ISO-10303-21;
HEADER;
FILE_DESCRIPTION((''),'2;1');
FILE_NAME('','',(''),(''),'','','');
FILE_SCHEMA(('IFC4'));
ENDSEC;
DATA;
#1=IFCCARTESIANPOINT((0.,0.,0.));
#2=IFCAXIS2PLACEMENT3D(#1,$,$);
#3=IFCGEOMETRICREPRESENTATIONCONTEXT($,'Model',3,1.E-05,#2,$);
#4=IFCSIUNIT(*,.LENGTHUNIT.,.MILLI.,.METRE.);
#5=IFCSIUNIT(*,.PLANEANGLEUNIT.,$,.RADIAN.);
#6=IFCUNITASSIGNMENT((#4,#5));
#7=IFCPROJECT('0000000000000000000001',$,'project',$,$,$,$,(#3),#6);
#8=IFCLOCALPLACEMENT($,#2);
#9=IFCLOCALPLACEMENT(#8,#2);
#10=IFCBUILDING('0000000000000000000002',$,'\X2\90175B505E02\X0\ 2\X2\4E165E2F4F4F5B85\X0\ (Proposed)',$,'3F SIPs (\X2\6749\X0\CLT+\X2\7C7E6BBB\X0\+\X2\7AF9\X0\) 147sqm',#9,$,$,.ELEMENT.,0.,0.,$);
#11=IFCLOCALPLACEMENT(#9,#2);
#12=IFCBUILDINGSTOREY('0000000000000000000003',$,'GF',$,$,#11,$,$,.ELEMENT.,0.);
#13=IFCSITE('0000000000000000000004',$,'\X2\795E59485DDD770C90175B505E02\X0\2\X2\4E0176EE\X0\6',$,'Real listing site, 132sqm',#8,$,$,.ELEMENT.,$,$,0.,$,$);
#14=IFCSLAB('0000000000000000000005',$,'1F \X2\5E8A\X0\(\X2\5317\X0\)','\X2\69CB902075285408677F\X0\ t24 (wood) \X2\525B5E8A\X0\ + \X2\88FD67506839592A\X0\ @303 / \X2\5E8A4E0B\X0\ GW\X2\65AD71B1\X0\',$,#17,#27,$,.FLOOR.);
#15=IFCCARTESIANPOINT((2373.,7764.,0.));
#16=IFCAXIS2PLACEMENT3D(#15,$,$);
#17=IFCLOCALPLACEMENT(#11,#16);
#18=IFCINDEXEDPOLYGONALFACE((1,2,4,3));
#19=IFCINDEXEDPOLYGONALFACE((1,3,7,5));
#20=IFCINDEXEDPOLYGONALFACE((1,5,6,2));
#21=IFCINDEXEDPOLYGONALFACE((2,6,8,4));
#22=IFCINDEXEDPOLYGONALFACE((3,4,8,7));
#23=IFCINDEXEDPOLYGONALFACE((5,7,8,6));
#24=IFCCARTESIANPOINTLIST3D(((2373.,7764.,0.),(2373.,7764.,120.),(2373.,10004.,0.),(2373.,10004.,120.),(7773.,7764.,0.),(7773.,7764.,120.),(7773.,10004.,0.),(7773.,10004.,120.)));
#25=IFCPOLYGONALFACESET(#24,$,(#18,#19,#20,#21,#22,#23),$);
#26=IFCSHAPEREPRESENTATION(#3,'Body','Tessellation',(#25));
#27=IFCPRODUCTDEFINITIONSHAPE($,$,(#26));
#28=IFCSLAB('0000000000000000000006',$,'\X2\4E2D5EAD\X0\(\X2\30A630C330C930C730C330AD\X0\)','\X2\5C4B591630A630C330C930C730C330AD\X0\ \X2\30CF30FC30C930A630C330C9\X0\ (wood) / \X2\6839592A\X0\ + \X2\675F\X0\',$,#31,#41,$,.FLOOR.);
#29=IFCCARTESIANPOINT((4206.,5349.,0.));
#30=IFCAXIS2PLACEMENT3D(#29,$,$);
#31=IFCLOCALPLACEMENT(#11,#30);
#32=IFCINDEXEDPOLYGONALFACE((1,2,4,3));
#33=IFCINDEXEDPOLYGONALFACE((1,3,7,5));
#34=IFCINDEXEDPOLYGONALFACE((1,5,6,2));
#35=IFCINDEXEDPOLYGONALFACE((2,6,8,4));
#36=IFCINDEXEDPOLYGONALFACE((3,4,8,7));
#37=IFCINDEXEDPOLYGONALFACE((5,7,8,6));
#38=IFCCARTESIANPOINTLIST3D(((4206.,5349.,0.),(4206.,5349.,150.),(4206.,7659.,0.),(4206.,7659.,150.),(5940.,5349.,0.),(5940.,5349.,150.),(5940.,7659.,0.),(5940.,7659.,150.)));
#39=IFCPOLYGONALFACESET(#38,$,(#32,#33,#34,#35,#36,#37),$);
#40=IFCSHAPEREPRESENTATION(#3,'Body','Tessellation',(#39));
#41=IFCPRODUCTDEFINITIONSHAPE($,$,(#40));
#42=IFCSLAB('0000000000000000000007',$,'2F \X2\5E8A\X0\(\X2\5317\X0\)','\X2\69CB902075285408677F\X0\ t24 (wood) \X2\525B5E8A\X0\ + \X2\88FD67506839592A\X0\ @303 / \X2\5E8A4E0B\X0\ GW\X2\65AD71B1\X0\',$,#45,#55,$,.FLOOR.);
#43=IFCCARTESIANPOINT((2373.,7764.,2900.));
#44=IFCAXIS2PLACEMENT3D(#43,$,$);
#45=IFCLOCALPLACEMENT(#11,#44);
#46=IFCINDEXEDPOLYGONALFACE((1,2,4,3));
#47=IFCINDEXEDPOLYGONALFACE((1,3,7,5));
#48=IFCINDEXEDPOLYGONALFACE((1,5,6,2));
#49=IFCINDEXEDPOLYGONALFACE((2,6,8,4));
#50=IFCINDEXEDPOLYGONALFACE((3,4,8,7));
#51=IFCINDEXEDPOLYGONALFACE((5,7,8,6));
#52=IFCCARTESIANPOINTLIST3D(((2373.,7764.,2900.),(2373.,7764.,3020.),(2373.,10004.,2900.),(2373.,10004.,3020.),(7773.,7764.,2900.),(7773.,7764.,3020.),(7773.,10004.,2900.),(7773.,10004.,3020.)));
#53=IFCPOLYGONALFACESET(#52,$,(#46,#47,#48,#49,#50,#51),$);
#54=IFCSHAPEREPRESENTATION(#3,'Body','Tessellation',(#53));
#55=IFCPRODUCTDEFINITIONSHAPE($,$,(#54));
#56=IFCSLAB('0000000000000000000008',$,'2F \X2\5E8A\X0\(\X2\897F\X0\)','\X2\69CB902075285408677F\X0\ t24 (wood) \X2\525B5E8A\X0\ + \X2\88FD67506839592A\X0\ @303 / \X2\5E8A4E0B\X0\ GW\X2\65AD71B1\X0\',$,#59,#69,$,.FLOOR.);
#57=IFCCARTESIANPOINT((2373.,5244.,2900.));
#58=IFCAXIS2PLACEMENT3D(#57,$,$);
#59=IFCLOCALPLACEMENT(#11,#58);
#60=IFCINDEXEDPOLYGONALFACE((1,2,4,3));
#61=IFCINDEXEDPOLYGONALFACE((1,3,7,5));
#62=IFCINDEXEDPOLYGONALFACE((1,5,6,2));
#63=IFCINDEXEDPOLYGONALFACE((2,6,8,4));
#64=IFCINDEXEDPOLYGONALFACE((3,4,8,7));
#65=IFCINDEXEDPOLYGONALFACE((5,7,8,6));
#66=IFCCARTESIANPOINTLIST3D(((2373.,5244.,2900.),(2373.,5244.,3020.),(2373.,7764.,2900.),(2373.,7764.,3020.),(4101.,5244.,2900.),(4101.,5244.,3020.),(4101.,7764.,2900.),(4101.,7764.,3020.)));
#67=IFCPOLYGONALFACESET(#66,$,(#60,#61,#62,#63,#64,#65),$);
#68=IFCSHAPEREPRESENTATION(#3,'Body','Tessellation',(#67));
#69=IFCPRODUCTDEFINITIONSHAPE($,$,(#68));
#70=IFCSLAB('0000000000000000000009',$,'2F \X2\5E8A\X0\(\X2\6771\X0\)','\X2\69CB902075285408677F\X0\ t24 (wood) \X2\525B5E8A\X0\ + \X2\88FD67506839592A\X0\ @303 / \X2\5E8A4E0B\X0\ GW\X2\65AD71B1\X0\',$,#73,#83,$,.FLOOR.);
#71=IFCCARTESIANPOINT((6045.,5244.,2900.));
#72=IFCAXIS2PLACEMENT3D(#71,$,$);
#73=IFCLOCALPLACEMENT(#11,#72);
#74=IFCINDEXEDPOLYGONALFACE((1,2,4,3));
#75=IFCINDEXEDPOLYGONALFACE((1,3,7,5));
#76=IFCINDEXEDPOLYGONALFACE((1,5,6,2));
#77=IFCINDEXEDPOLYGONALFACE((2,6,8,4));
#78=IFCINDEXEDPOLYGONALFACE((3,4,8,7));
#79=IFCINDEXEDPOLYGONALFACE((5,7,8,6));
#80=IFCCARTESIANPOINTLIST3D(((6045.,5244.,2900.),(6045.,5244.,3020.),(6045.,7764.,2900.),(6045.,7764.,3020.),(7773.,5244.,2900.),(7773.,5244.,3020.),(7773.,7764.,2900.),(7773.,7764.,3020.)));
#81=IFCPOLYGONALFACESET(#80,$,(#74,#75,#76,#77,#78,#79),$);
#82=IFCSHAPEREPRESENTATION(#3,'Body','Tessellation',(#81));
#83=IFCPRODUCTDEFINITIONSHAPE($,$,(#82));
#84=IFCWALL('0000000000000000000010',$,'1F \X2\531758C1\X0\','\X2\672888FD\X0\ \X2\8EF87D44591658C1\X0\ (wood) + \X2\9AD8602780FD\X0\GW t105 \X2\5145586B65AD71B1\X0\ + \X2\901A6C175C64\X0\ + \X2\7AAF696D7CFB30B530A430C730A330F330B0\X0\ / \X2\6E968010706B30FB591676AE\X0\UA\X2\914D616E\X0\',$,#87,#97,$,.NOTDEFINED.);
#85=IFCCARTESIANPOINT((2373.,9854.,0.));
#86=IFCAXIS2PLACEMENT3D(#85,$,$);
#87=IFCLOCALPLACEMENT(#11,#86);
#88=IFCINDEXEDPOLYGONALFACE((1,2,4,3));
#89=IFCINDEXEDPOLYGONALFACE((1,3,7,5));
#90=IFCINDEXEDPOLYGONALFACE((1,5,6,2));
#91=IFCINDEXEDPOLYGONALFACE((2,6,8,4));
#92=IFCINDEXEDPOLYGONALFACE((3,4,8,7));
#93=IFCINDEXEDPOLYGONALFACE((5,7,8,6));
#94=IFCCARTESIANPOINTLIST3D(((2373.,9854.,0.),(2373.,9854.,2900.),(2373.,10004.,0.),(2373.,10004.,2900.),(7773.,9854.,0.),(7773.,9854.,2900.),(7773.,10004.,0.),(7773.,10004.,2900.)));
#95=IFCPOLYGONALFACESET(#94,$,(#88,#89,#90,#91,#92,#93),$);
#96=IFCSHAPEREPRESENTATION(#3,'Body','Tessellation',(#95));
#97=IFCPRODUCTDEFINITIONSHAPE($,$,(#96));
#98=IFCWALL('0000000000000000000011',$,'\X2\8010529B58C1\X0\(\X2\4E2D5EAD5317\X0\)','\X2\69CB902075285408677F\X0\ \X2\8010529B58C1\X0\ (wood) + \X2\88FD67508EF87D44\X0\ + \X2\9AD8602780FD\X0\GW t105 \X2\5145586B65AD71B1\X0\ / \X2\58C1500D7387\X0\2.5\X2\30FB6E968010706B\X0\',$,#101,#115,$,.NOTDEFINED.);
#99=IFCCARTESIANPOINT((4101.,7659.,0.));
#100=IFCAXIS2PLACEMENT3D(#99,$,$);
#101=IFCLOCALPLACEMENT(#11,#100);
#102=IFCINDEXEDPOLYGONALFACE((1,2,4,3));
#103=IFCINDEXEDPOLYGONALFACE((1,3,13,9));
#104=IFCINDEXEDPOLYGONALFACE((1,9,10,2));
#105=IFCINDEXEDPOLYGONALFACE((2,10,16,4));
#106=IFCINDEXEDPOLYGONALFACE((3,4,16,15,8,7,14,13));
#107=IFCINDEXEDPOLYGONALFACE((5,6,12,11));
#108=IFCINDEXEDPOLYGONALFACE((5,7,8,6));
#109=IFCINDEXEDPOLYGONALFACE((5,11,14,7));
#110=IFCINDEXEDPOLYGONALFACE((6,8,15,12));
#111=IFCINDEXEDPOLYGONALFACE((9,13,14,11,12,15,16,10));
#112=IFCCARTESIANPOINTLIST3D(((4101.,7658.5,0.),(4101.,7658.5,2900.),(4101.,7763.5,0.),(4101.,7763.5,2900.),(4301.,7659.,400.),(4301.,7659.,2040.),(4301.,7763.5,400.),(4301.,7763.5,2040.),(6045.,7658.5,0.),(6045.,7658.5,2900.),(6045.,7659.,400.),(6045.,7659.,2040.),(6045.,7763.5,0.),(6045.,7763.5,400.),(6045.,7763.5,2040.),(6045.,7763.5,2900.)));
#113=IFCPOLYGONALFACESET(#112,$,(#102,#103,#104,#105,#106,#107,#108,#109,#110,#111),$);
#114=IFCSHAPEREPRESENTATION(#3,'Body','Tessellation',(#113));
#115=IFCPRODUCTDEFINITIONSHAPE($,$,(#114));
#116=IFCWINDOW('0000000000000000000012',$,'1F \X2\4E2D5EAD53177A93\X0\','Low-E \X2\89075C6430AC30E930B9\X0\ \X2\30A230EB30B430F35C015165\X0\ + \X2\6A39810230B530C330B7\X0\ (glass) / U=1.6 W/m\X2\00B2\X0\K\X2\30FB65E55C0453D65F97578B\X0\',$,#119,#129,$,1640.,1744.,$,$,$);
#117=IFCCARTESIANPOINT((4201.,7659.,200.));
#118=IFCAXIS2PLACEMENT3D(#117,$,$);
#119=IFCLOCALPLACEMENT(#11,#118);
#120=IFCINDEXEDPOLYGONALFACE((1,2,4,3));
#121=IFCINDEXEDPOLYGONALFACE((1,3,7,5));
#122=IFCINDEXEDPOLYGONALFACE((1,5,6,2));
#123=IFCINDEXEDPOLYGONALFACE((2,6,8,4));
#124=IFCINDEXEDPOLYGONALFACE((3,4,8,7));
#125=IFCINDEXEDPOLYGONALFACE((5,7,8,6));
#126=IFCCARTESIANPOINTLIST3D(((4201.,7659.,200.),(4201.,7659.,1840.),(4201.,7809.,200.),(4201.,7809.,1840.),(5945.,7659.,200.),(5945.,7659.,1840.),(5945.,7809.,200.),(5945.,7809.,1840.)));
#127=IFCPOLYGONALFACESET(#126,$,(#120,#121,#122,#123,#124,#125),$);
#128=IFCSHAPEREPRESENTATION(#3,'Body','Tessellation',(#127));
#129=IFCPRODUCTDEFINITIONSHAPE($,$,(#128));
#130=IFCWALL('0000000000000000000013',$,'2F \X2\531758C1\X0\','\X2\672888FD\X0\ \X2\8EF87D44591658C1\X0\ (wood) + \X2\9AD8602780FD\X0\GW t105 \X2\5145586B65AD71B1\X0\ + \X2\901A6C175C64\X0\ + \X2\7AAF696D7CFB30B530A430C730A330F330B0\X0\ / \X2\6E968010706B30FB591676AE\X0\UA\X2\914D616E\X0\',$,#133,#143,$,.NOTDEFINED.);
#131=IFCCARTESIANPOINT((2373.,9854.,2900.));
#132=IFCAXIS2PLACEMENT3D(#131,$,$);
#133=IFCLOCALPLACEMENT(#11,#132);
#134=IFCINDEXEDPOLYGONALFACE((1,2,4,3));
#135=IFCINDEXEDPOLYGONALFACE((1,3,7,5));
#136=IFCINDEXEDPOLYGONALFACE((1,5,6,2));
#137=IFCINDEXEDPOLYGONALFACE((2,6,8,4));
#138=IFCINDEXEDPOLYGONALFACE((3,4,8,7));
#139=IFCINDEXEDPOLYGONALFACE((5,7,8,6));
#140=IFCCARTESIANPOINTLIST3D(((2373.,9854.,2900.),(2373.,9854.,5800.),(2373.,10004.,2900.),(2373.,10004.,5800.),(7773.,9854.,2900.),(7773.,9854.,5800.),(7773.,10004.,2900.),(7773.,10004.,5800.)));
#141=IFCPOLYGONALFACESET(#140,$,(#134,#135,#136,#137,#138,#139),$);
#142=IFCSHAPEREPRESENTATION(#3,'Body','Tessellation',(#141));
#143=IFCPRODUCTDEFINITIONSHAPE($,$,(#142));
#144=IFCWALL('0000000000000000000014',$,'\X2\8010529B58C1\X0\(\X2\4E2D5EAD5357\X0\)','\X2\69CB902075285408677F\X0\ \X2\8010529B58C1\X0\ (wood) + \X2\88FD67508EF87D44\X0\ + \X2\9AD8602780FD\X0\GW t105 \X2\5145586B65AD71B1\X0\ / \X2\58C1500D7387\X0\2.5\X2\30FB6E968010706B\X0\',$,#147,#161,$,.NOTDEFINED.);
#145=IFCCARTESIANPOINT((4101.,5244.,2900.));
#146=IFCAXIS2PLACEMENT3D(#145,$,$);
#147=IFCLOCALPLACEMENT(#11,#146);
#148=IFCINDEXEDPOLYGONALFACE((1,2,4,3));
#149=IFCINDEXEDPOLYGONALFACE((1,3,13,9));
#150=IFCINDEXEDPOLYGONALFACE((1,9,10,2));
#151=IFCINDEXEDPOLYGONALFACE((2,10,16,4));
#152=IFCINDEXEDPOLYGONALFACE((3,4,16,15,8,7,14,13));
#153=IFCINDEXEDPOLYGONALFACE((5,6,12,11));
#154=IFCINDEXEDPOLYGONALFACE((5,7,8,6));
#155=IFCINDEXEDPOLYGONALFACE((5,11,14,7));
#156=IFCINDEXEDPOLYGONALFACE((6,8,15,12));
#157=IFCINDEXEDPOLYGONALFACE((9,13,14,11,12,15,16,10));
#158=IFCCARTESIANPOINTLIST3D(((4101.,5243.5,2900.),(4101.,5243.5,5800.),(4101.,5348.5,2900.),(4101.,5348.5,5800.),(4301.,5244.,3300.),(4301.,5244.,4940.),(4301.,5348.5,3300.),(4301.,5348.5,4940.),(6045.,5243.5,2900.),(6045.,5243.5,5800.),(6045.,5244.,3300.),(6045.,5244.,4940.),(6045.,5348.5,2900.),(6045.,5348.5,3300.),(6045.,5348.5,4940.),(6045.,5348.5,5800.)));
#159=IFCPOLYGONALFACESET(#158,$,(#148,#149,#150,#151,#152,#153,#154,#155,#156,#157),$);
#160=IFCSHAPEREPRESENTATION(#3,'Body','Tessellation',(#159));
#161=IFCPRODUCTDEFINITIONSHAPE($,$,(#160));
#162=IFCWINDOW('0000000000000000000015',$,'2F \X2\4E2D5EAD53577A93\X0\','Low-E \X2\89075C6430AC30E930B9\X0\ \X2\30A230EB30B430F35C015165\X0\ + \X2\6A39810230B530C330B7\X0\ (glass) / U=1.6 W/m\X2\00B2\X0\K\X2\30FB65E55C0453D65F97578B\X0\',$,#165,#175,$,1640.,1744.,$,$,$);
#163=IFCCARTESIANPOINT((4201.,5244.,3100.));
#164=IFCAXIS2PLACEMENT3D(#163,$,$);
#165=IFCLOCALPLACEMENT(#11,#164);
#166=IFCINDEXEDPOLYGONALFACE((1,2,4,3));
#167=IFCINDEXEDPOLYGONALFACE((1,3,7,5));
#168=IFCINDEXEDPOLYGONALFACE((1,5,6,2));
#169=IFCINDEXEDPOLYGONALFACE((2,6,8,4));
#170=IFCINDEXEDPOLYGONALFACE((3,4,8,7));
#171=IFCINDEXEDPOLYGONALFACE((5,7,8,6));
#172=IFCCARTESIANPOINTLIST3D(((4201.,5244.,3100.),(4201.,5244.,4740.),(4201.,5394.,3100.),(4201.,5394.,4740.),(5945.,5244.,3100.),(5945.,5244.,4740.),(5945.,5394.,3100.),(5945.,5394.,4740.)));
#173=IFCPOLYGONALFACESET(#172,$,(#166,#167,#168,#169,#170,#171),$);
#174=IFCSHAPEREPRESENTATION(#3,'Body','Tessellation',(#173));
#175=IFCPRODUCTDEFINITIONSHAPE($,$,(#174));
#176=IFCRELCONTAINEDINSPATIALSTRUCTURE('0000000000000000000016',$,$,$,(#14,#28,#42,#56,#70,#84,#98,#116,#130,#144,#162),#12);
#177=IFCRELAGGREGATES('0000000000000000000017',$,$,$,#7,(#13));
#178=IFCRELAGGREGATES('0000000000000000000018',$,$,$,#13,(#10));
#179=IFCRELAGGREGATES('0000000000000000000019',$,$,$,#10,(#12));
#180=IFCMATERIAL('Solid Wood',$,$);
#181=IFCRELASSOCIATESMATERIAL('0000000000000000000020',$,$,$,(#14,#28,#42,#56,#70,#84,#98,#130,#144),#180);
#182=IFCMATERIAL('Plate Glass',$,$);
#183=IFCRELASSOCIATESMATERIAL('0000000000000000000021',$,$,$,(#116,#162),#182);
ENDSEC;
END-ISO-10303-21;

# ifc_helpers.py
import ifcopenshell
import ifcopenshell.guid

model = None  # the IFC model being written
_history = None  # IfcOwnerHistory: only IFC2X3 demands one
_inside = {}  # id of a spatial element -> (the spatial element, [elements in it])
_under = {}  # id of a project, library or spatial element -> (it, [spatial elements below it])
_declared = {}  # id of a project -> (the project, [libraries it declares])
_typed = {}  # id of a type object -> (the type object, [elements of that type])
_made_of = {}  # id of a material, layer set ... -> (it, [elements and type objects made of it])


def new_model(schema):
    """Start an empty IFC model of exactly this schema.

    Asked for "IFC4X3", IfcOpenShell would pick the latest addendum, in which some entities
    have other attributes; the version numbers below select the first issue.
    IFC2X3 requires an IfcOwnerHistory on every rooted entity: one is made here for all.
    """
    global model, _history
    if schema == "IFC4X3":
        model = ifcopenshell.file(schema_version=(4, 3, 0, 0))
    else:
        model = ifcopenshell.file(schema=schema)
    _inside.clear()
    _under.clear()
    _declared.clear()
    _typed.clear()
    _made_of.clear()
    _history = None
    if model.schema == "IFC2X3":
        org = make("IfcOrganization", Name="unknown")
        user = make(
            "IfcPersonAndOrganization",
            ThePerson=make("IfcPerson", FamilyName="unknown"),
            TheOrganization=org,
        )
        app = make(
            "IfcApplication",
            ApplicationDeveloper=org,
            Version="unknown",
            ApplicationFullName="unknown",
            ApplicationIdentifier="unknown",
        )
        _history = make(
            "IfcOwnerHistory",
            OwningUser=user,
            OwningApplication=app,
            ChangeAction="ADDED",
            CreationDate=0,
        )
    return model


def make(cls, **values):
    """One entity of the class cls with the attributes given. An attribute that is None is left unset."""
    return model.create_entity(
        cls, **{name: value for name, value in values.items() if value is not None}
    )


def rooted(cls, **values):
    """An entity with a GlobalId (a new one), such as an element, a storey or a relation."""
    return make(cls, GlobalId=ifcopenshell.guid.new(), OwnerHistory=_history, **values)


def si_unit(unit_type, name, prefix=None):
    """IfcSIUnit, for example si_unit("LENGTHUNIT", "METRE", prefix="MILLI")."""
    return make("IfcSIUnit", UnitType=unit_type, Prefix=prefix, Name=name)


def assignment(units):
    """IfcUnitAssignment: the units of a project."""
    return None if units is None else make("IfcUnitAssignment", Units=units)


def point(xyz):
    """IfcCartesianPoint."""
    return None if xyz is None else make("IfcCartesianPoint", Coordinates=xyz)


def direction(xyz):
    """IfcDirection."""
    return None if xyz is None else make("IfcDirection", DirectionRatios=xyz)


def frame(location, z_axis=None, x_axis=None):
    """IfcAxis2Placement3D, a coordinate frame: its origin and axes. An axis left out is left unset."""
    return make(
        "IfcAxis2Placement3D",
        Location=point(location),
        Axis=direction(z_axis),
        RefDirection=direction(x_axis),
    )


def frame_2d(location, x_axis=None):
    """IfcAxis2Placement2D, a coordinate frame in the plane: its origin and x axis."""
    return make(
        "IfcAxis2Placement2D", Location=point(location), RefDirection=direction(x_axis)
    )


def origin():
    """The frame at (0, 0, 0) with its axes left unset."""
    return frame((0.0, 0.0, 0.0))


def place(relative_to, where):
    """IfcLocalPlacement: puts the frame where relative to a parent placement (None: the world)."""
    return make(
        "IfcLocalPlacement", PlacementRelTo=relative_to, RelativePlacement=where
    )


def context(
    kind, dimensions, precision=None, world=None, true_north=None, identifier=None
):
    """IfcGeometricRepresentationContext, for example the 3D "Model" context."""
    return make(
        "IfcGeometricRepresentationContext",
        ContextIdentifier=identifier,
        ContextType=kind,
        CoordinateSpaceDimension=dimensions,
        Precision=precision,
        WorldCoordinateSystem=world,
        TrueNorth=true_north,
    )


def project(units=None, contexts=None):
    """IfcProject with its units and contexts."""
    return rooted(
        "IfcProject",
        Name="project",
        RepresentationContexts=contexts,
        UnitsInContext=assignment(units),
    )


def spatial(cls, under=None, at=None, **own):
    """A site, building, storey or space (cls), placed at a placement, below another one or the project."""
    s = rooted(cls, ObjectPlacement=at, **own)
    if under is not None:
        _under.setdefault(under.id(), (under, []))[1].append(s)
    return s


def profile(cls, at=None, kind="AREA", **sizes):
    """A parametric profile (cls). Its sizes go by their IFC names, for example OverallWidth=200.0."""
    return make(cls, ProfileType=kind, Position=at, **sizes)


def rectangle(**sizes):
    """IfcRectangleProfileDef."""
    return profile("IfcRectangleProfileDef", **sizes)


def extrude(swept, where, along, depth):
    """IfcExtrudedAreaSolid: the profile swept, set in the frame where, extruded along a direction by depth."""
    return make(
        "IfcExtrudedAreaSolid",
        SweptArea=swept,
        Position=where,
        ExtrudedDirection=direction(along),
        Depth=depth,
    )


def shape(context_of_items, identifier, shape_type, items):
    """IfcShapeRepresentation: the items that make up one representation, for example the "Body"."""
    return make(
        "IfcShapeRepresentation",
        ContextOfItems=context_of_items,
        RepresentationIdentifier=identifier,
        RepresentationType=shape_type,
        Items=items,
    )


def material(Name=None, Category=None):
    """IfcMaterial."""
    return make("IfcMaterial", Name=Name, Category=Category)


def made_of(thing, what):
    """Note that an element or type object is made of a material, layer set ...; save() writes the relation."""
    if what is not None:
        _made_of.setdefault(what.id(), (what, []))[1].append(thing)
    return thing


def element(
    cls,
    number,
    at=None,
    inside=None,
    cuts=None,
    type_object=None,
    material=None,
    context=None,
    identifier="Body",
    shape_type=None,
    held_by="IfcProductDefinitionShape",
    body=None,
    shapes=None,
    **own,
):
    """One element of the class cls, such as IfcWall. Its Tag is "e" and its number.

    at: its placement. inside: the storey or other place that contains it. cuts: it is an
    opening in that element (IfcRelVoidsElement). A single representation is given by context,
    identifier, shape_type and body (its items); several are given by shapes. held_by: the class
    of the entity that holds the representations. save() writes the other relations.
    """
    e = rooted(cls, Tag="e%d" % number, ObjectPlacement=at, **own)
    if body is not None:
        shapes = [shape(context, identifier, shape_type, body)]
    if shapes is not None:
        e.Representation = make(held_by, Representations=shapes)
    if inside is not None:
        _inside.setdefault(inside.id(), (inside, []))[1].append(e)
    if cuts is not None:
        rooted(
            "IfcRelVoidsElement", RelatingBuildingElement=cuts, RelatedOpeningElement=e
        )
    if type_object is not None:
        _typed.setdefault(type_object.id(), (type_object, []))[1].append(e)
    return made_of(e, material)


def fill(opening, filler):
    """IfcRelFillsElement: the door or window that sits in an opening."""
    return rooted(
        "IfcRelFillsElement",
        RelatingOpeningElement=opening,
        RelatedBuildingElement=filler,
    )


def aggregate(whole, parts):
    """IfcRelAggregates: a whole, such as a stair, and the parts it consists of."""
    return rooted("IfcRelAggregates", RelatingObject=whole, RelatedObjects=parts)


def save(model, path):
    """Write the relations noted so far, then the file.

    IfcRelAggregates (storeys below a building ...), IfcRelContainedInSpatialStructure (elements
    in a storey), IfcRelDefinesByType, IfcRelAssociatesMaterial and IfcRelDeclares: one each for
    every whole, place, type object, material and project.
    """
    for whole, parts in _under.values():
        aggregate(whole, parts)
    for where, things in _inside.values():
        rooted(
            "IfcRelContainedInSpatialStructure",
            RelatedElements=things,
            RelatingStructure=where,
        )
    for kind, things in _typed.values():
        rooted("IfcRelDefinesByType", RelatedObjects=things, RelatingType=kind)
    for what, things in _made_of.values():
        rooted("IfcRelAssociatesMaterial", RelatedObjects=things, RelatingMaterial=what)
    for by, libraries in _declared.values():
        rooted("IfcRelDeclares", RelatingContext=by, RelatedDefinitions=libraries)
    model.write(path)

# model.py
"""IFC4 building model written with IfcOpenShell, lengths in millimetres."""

from ifc_helpers import new_model, si_unit, frame, frame_2d, origin, place, context, project, spatial, rectangle, extrude, material, element, fill, save


model = new_model("IFC4")

# Units and contexts
model_context = context("Model", 3, precision=1e-05, world=origin())
ifc_project = project(units=[si_unit("LENGTHUNIT", "METRE", prefix="MILLI"), si_unit("PLANEANGLEUNIT", "RADIAN")], contexts=[model_context])

# Site, building, storey
site_placement = place(None, origin())
site = spatial("IfcSite", under=ifc_project, at=site_placement, Name="神奈川県逗子市2丁目6", ObjectType="Real listing site, 132sqm", CompositionType="ELEMENT", RefElevation=0.0)
building_placement = place(site_placement, origin())
building = spatial("IfcBuilding", under=site, at=building_placement, Name="逗子市 2世帯住宅 (Proposed)", ObjectType="3F SIPs (杉CLT+籾殻+竹) 147sqm", CompositionType="ELEMENT", ElevationOfRefHeight=0.0, ElevationOfTerrain=0.0)
storey_placement = place(building_placement, origin())
storey = spatial("IfcBuildingStorey", under=building, at=storey_placement, Name="GF", CompositionType="ELEMENT", Elevation=0.0)

# Slabs
ifc_material_1 = material(Name="Solid Wood")
slab_1_placement = place(storey_placement, frame((2373.0, 7764.0, 0.0)))
element("IfcSlab", 1, at=slab_1_placement, inside=storey, material=ifc_material_1, Name="1F 床(北)", Description="構造用合板 t24 (wood) 剛床 + 製材根太 @303 / 床下 GW断熱", PredefinedType="FLOOR", context=model_context, shape_type="SweptSolid", body=[
    extrude(rectangle(XDim=5400.0, YDim=2240.0, at=frame_2d((2700.0, 1120.0))), frame((2373.0, 7764.0, 0.0)), (0.0, 0.0, 1.0), 120.0),
])
slab_2_placement = place(storey_placement, frame((4206.0, 5349.0, 0.0)))
element("IfcSlab", 2, at=slab_2_placement, inside=storey, material=ifc_material_1, Name="中庭(ウッドデッキ)", Description="屋外ウッドデッキ ハードウッド (wood) / 根太 + 束", PredefinedType="FLOOR", context=model_context, shape_type="SweptSolid", body=[
    extrude(rectangle(XDim=1734.0, YDim=2310.0, at=frame_2d((867.0, 1155.0))), frame((4206.0, 5349.0, 0.0)), (0.0, 0.0, 1.0), 150.0),
])
slab_3_placement = place(storey_placement, frame((2373.0, 7764.0, 2900.0)))
element("IfcSlab", 3, at=slab_3_placement, inside=storey, material=ifc_material_1, Name="2F 床(北)", Description="構造用合板 t24 (wood) 剛床 + 製材根太 @303 / 床下 GW断熱", PredefinedType="FLOOR", context=model_context, shape_type="SweptSolid", body=[
    extrude(rectangle(XDim=5400.0, YDim=2240.0, at=frame_2d((2700.0, 1120.0))), frame((2373.0, 7764.0, 2900.0)), (0.0, 0.0, 1.0), 120.0),
])
slab_4_placement = place(storey_placement, frame((2373.0, 5244.0, 2900.0)))
element("IfcSlab", 4, at=slab_4_placement, inside=storey, material=ifc_material_1, Name="2F 床(西)", Description="構造用合板 t24 (wood) 剛床 + 製材根太 @303 / 床下 GW断熱", PredefinedType="FLOOR", context=model_context, shape_type="SweptSolid", body=[
    extrude(rectangle(XDim=1728.0, YDim=2520.0, at=frame_2d((864.0, 1260.0))), frame((2373.0, 5244.0, 2900.0)), (0.0, 0.0, 1.0), 120.0),
])
slab_5_placement = place(storey_placement, frame((6045.0, 5244.0, 2900.0)))
element("IfcSlab", 5, at=slab_5_placement, inside=storey, material=ifc_material_1, Name="2F 床(東)", Description="構造用合板 t24 (wood) 剛床 + 製材根太 @303 / 床下 GW断熱", PredefinedType="FLOOR", context=model_context, shape_type="SweptSolid", body=[
    extrude(rectangle(XDim=1728.0, YDim=2520.0, at=frame_2d((864.0, 1260.0))), frame((6045.0, 5244.0, 2900.0)), (0.0, 0.0, 1.0), 120.0),
])

# Wall
wall_1_placement = place(storey_placement, frame((2373.0, 9854.0, 0.0)))
element("IfcWall", 6, at=wall_1_placement, inside=storey, material=ifc_material_1, Name="1F 北壁", Description="木製 軸組外壁 (wood) + 高性能GW t105 充填断熱 + 通気層 + 窯業系サイディング / 準耐火・外皮UA配慮", PredefinedType="NOTDEFINED", context=model_context, shape_type="SweptSolid", body=[
    extrude(rectangle(XDim=5400.0, YDim=150.0, at=frame_2d((2700.0, 75.0))), frame((2373.0, 9854.0, 0.0)), (0.0, 0.0, 1.0), 2900.0),
])

# Wall, opening, window
wall_2_placement = place(storey_placement, frame((4101.0, 7659.0, 0.0)))
wall_2 = element("IfcWall", 7, at=wall_2_placement, inside=storey, material=ifc_material_1, Name="耐力壁(中庭北)", Description="構造用合板 耐力壁 (wood) + 製材軸組 + 高性能GW t105 充填断熱 / 壁倍率2.5・準耐火", PredefinedType="NOTDEFINED", context=model_context, shape_type="SweptSolid", body=[
    extrude(rectangle(XDim=1944.0, YDim=105.0, at=frame_2d((972.0, 52.0))), frame((4101.0, 7659.0, 0.0)), (0.0, 0.0, 1.0), 2900.0),
])
opening_1_placement = place(storey_placement, frame((4201.0, 7659.0, 200.0)))
opening_1 = element("IfcOpeningElement", 8, at=opening_1_placement, cuts=wall_2, PredefinedType="NOTDEFINED", context=model_context, shape_type="SweptSolid", body=[
    extrude(rectangle(XDim=1744.0, YDim=150.0, at=frame_2d((872.0, 75.0))), frame((4201.0, 7659.0, 200.0)), (0.0, 0.0, 1.0), 1640.0),
])
ifc_material_2 = material(Name="Plate Glass")
window_1_placement = place(storey_placement, frame((4201.0, 7659.0, 200.0)))
window_1 = element("IfcWindow", 9, at=window_1_placement, inside=storey, material=ifc_material_2, Name="1F 中庭北窓", Description="Low-E 複層ガラス アルゴン封入 + 樹脂サッシ (glass) / U=1.6 W/m²K・日射取得型", OverallHeight=1640.0, OverallWidth=1744.0, context=model_context, shape_type="SweptSolid", body=[
    extrude(rectangle(XDim=1744.0, YDim=150.0, at=frame_2d((872.0, 75.0))), frame((4201.0, 7659.0, 200.0)), (0.0, 0.0, 1.0), 1640.0),
])
fill(opening_1, window_1)

# Wall
wall_3_placement = place(storey_placement, frame((2373.0, 9854.0, 2900.0)))
element("IfcWall", 10, at=wall_3_placement, inside=storey, material=ifc_material_1, Name="2F 北壁", Description="木製 軸組外壁 (wood) + 高性能GW t105 充填断熱 + 通気層 + 窯業系サイディング / 準耐火・外皮UA配慮", PredefinedType="NOTDEFINED", context=model_context, shape_type="SweptSolid", body=[
    extrude(rectangle(XDim=5400.0, YDim=150.0, at=frame_2d((2700.0, 75.0))), frame((2373.0, 9854.0, 2900.0)), (0.0, 0.0, 1.0), 2900.0),
])

# Wall, opening, window
wall_4_placement = place(storey_placement, frame((4101.0, 5244.0, 2900.0)))
wall_4 = element("IfcWall", 11, at=wall_4_placement, inside=storey, material=ifc_material_1, Name="耐力壁(中庭南)", Description="構造用合板 耐力壁 (wood) + 製材軸組 + 高性能GW t105 充填断熱 / 壁倍率2.5・準耐火", PredefinedType="NOTDEFINED", context=model_context, shape_type="SweptSolid", body=[
    extrude(rectangle(XDim=1944.0, YDim=105.0, at=frame_2d((972.0, 52.0))), frame((4101.0, 5244.0, 2900.0)), (0.0, 0.0, 1.0), 2900.0),
])
opening_2_placement = place(storey_placement, frame((4201.0, 5244.0, 3100.0)))
opening_2 = element("IfcOpeningElement", 12, at=opening_2_placement, cuts=wall_4, PredefinedType="NOTDEFINED", context=model_context, shape_type="SweptSolid", body=[
    extrude(rectangle(XDim=1744.0, YDim=150.0, at=frame_2d((872.0, 75.0))), frame((4201.0, 5244.0, 3100.0)), (0.0, 0.0, 1.0), 1640.0),
])
window_2_placement = place(storey_placement, frame((4201.0, 5244.0, 3100.0)))
window_2 = element("IfcWindow", 13, at=window_2_placement, inside=storey, material=ifc_material_2, Name="2F 中庭南窓", Description="Low-E 複層ガラス アルゴン封入 + 樹脂サッシ (glass) / U=1.6 W/m²K・日射取得型", OverallHeight=1640.0, OverallWidth=1744.0, context=model_context, shape_type="SweptSolid", body=[
    extrude(rectangle(XDim=1744.0, YDim=150.0, at=frame_2d((872.0, 75.0))), frame((4201.0, 5244.0, 3100.0)), (0.0, 0.0, 1.0), 1640.0),
])
fill(opening_2, window_2)

save(model, "model.ifc")
